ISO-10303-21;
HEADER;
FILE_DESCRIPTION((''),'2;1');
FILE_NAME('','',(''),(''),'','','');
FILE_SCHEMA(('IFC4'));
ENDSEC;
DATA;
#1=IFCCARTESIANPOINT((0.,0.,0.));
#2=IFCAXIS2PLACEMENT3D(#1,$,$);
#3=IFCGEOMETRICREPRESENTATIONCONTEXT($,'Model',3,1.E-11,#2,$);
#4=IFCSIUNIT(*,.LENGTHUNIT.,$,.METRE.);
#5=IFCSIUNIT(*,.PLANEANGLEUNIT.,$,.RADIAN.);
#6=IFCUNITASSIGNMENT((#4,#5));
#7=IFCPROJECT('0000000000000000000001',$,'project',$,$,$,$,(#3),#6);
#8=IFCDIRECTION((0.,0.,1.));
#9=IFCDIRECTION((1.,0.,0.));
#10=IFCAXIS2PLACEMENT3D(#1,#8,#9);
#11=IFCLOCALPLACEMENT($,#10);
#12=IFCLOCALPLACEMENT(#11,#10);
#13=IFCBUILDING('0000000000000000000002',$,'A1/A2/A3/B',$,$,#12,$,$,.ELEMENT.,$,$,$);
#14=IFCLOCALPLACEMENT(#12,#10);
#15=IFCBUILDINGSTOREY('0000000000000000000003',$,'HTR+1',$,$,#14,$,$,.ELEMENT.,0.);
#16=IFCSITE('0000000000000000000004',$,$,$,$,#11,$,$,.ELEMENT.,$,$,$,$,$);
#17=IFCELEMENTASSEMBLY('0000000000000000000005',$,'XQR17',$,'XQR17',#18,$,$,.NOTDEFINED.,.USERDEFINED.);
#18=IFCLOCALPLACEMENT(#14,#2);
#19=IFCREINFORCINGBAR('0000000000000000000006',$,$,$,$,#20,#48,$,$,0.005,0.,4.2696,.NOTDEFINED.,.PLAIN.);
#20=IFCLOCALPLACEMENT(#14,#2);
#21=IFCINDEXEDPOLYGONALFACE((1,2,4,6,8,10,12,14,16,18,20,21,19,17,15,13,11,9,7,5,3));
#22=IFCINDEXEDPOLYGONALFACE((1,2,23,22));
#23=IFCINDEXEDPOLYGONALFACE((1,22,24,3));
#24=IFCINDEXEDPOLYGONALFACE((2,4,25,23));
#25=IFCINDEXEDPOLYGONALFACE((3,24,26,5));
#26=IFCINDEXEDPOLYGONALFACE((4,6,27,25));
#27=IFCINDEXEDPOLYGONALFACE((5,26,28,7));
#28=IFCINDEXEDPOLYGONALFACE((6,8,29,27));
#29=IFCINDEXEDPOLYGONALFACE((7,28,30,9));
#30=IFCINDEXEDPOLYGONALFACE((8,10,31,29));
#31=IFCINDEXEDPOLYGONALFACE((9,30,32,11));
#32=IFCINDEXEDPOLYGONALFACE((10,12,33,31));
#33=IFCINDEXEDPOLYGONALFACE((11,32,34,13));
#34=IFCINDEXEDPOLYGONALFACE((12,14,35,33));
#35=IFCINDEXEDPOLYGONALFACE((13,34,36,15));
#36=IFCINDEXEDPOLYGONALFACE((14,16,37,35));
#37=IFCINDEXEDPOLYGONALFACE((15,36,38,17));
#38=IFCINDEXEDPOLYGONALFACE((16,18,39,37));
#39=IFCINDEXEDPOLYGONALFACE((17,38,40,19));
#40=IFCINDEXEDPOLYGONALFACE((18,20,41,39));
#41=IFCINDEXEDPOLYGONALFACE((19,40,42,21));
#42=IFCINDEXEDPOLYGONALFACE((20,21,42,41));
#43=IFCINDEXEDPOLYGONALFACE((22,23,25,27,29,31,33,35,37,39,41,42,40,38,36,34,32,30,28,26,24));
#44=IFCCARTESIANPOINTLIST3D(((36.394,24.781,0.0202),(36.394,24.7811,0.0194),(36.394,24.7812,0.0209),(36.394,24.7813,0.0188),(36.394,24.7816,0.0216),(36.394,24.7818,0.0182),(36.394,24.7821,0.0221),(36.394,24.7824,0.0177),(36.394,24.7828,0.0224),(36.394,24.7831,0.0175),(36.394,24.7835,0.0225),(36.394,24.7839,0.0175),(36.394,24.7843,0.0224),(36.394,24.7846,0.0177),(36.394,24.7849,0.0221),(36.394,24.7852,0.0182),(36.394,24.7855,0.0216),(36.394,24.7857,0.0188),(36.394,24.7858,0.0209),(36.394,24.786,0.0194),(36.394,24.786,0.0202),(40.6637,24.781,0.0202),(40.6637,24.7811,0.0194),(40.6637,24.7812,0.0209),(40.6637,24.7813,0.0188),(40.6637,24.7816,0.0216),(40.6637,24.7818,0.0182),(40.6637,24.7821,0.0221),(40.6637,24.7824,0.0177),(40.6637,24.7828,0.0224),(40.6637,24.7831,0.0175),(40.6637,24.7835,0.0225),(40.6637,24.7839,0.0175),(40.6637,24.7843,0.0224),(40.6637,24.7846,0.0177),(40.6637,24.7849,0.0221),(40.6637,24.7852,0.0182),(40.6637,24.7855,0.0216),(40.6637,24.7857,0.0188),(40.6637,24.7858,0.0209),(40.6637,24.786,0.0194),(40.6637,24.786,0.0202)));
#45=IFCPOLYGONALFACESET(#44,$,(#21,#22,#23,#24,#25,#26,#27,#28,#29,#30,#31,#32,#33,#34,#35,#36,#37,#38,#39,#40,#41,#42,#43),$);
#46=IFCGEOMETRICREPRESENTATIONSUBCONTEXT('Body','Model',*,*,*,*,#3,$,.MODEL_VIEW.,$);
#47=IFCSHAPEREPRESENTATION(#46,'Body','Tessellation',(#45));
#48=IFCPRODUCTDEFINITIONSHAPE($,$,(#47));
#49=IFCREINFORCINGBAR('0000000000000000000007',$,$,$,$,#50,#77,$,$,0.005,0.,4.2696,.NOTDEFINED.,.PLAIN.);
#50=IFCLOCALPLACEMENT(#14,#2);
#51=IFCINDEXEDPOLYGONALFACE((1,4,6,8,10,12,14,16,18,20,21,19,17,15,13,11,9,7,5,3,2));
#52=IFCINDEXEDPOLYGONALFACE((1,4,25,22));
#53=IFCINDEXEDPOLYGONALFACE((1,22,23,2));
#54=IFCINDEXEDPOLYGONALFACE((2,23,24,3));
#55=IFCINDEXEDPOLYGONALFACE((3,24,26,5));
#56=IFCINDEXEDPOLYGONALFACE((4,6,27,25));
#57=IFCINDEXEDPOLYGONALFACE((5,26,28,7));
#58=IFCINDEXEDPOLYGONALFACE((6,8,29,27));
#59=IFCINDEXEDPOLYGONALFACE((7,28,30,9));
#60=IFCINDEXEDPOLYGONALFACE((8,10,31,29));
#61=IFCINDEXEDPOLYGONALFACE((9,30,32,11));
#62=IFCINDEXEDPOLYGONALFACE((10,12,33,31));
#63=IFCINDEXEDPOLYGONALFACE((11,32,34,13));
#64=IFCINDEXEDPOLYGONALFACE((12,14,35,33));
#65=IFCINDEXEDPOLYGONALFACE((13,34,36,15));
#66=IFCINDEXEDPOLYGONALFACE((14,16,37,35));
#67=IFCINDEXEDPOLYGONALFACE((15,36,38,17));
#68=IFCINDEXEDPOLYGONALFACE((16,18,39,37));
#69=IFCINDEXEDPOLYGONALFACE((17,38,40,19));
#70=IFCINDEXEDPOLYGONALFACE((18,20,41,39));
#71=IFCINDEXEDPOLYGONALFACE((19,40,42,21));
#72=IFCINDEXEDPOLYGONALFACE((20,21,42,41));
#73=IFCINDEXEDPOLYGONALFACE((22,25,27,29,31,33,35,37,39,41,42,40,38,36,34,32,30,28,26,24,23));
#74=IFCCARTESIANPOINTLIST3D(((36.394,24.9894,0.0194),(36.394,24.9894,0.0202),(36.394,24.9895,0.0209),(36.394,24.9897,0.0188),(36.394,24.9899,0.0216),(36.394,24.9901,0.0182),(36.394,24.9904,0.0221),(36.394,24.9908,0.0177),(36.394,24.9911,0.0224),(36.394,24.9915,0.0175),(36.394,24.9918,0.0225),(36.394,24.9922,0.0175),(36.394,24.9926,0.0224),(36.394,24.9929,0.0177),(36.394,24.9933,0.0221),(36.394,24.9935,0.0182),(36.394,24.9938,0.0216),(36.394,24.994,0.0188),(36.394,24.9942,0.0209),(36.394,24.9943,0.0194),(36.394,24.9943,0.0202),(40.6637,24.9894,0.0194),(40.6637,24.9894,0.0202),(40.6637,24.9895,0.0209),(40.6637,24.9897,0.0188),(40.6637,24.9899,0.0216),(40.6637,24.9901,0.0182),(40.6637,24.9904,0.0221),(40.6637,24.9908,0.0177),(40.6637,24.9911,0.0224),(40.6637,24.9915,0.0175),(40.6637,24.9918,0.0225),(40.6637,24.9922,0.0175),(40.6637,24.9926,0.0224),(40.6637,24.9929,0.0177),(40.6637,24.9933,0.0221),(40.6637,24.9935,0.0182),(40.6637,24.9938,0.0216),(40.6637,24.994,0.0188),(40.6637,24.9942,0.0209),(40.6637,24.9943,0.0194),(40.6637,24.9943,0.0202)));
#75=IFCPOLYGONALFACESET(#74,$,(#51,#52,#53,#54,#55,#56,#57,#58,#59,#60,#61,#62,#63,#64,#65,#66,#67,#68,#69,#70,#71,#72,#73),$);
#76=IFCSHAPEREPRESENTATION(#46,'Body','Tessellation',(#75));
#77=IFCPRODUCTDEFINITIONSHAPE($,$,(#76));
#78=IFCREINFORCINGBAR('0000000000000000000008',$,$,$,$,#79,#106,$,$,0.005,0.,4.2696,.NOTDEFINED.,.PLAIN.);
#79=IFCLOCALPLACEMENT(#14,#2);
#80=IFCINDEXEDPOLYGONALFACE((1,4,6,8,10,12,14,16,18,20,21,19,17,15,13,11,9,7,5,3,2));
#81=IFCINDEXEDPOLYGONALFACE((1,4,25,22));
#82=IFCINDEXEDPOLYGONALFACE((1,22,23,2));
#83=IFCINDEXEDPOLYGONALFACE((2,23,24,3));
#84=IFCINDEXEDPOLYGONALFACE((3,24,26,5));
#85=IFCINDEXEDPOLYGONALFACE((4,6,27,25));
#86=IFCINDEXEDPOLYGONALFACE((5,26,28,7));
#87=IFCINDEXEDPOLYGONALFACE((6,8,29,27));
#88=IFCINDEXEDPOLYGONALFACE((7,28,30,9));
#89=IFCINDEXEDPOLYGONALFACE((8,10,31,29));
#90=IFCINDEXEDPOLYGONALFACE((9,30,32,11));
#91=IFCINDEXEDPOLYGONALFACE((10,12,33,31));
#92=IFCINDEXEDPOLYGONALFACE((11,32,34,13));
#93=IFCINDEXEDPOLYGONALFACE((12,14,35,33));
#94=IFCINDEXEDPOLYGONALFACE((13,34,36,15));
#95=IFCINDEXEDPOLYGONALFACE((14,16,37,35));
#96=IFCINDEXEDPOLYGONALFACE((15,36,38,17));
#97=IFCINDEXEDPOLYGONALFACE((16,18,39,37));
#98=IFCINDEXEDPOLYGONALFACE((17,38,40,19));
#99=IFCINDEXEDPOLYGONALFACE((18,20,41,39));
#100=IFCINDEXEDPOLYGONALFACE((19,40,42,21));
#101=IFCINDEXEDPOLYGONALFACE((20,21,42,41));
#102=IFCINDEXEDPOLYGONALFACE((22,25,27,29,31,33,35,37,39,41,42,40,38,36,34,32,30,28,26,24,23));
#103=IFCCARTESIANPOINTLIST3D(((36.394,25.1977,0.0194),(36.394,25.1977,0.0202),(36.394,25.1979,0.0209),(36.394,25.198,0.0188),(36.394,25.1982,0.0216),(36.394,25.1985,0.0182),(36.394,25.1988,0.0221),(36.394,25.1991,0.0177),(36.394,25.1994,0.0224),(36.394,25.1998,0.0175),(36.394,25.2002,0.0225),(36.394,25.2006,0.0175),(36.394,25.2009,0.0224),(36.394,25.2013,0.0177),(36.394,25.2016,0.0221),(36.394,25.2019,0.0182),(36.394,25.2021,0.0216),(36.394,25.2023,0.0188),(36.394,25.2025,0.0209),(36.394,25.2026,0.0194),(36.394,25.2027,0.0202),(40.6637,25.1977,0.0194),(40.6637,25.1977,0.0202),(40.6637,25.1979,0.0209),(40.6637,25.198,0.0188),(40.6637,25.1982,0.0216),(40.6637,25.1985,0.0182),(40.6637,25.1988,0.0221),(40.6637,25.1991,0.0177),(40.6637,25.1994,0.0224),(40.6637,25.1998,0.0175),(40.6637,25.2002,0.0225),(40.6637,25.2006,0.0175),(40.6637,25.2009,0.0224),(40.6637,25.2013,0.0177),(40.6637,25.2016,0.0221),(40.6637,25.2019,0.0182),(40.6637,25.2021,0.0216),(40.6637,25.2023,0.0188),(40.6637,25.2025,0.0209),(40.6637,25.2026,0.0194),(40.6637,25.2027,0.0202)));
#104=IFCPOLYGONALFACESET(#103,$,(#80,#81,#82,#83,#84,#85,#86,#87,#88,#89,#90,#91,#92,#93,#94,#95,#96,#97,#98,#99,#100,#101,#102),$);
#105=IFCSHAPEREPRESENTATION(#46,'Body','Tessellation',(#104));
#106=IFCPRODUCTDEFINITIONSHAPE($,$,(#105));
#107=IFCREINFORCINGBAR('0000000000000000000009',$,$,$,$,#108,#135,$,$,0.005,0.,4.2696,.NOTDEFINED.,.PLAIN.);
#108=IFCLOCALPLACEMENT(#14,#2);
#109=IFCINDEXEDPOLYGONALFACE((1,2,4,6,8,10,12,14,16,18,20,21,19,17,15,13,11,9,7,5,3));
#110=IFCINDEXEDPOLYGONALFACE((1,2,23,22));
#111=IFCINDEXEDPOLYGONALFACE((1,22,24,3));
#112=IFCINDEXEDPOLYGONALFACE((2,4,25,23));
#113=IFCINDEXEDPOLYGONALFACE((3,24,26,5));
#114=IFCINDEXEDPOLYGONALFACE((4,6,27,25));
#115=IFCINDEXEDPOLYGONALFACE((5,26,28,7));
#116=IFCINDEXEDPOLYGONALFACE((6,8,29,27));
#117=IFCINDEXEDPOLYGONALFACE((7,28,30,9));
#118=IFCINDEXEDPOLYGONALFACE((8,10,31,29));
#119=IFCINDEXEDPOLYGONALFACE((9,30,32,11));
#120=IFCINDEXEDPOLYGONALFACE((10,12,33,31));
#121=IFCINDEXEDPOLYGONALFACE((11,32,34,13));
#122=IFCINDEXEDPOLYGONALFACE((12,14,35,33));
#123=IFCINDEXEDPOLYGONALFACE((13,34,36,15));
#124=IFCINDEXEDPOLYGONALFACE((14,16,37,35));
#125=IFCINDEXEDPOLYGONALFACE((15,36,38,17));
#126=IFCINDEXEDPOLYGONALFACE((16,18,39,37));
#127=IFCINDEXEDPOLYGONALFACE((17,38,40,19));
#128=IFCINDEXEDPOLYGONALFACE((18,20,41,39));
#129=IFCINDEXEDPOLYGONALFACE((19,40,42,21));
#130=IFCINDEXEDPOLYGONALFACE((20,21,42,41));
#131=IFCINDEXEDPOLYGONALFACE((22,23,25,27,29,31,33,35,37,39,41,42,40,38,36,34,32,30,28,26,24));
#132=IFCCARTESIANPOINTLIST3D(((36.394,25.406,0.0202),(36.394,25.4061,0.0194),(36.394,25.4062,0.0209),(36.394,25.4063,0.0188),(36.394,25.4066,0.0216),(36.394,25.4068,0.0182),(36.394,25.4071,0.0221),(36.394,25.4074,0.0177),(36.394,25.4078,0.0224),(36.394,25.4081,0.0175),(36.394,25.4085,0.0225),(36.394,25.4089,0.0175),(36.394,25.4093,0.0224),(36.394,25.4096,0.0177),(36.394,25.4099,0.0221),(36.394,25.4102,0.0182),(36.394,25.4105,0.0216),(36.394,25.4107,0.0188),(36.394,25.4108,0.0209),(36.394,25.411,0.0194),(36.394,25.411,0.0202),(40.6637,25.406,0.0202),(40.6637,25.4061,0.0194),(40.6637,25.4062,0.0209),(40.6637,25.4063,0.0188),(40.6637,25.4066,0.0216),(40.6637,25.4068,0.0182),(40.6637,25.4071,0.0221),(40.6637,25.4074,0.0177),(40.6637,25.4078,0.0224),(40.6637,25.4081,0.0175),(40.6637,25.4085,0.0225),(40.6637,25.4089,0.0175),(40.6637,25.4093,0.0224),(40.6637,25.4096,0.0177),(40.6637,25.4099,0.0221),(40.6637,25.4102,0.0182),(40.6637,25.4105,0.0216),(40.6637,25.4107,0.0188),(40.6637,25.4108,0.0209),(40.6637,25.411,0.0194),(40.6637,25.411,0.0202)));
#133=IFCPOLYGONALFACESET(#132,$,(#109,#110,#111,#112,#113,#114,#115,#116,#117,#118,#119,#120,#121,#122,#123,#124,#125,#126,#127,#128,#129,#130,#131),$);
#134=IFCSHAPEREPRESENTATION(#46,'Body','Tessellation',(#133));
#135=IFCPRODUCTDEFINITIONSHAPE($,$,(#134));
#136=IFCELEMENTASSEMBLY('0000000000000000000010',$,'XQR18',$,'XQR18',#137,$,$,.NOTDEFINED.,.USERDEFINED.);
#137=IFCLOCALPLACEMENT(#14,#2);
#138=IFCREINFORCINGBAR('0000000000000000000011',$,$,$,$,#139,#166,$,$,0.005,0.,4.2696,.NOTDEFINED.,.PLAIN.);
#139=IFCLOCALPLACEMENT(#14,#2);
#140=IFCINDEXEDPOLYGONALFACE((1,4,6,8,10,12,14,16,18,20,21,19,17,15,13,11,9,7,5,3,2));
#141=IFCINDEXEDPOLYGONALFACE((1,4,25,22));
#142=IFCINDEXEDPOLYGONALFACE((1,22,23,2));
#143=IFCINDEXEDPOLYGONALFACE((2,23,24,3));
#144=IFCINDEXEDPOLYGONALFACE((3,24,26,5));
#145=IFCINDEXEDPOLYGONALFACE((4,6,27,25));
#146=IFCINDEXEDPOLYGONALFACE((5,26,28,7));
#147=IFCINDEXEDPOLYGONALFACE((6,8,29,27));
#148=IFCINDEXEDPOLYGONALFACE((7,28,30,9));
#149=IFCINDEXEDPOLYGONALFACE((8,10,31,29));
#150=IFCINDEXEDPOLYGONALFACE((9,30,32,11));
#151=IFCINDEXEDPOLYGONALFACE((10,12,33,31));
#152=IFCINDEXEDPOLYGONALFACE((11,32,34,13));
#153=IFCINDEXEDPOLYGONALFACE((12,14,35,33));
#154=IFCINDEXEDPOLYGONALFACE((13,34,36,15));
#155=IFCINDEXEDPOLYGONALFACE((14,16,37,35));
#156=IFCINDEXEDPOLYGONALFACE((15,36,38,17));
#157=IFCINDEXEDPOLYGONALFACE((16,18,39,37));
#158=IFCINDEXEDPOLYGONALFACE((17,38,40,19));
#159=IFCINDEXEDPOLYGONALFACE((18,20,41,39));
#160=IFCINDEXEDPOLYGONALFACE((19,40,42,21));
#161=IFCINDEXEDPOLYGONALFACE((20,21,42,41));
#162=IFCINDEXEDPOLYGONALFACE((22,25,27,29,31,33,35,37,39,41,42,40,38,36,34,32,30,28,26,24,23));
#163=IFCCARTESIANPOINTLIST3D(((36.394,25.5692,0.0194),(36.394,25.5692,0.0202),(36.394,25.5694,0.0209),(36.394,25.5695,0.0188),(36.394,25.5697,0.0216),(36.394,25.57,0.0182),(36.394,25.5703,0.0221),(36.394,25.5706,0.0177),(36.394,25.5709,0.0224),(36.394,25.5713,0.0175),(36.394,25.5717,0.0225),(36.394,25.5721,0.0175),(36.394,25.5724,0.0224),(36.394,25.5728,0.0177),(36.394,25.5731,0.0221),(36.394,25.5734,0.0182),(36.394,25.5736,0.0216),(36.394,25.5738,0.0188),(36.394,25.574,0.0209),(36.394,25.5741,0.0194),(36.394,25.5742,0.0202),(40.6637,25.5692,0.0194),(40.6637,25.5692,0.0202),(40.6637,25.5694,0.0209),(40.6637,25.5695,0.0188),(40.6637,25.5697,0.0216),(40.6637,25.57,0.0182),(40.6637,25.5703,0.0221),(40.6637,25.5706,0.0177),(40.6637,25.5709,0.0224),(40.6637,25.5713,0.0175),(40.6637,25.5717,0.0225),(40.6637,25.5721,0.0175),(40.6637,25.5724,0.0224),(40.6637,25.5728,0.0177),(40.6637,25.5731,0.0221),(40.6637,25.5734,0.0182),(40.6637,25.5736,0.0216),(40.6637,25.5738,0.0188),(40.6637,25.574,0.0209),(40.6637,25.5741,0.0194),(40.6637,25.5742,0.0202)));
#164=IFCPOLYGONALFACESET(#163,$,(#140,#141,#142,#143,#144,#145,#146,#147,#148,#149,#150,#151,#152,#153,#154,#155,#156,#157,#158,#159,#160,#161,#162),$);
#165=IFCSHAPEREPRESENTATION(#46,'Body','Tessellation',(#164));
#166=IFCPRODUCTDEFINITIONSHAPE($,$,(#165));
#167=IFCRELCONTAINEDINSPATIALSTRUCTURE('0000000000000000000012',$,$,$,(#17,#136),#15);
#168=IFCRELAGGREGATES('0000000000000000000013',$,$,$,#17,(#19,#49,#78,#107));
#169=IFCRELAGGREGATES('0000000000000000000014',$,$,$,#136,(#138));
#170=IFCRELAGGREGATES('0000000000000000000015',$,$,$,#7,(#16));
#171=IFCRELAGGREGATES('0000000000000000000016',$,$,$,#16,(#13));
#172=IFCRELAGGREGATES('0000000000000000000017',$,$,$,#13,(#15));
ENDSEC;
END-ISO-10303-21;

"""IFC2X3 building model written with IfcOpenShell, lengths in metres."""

from ifc_helpers import new_model, entity, si_unit, origin, origin_with_axes, place, context, subcontext, project, spatial, shape, element, aggregate, save


model = new_model("IFC2X3")

# Units and contexts
model_context = context("Model", 3, precision=1e-11, world=origin())
body_context = subcontext(model_context, "Body", "Model", "MODEL_VIEW")
ifc_project = project(units=[si_unit("LENGTHUNIT", "METRE"), si_unit("PLANEANGLEUNIT", "RADIAN")], contexts=[model_context])

# Site, building, storey
site_placement = place(None, origin_with_axes())
site = spatial("IfcSite", under=ifc_project, at=site_placement, CompositionType="ELEMENT")
building_placement = place(site_placement, origin_with_axes())
building = spatial("IfcBuilding", under=site, at=building_placement, Name="A1/A2/A3/B", CompositionType="ELEMENT")
storey_placement = place(building_placement, origin_with_axes())
storey = spatial("IfcBuildingStorey", under=building, at=storey_placement, Name="HTR+1", CompositionType="ELEMENT", Elevation=0.0)

# Element assemblies, reinforcing bars
assembly_1_placement = place(storey_placement, origin_with_axes())
assembly_1 = element("IfcElementAssembly", 1, at=assembly_1_placement, inside=storey, Name="XQR17", ObjectType="XQR17", AssemblyPlace="NOTDEFINED", PredefinedType="USERDEFINED")
reinforcing_bar_1_placement = place(assembly_1_placement, origin_with_axes())
reinforcing_bar_1 = element("IfcReinforcingBar", 2, at=reinforcing_bar_1_placement, BarLength=4.2696, BarRole="NOTDEFINED", BarSurface="PLAIN", CrossSectionArea=0.0, NominalDiameter=0.005, shapes=[
    shape(body_context, "Body", "AdvancedSweptSolid", [entity("IfcSweptDiskSolid", entity("IfcPolyline", [entity("IfcCartesianPoint", [36.394, 24.7835, 0.02]), entity("IfcCartesianPoint", [40.6637, 24.7835, 0.02])]), 0.0025, None, 0.0, 4.2696)]),
    shape(body_context, "Body", "AdvancedSweptSolid", [entity("IfcSweptDiskSolid", entity("IfcPolyline", [entity("IfcCartesianPoint", [36.394, 24.7835, 0.02]), entity("IfcCartesianPoint", [40.6637, 24.7835, 0.02])]), 0.0025, None, 0.0, 4.2696)]),
])
reinforcing_bar_2_placement = place(assembly_1_placement, origin_with_axes())
reinforcing_bar_2 = element("IfcReinforcingBar", 3, at=reinforcing_bar_2_placement, BarLength=4.2696, BarRole="NOTDEFINED", BarSurface="PLAIN", CrossSectionArea=0.0, NominalDiameter=0.005, shapes=[
    shape(body_context, "Body", "AdvancedSweptSolid", [entity("IfcSweptDiskSolid", entity("IfcPolyline", [entity("IfcCartesianPoint", [36.394, 24.9918, 0.02]), entity("IfcCartesianPoint", [40.6637, 24.9918, 0.02])]), 0.0025, None, 0.0, 4.2696)]),
    shape(body_context, "Body", "AdvancedSweptSolid", [entity("IfcSweptDiskSolid", entity("IfcPolyline", [entity("IfcCartesianPoint", [36.394, 24.9918, 0.02]), entity("IfcCartesianPoint", [40.6637, 24.9918, 0.02])]), 0.0025, None, 0.0, 4.2696)]),
])
reinforcing_bar_3_placement = place(assembly_1_placement, origin_with_axes())
reinforcing_bar_3 = element("IfcReinforcingBar", 4, at=reinforcing_bar_3_placement, BarLength=4.2696, BarRole="NOTDEFINED", BarSurface="PLAIN", CrossSectionArea=0.0, NominalDiameter=0.005, shapes=[
    shape(body_context, "Body", "AdvancedSweptSolid", [entity("IfcSweptDiskSolid", entity("IfcPolyline", [entity("IfcCartesianPoint", [36.394, 25.2002, 0.02]), entity("IfcCartesianPoint", [40.6637, 25.2002, 0.02])]), 0.0025, None, 0.0, 4.2696)]),
    shape(body_context, "Body", "AdvancedSweptSolid", [entity("IfcSweptDiskSolid", entity("IfcPolyline", [entity("IfcCartesianPoint", [36.394, 25.2002, 0.02]), entity("IfcCartesianPoint", [40.6637, 25.2002, 0.02])]), 0.0025, None, 0.0, 4.2696)]),
])
reinforcing_bar_4_placement = place(assembly_1_placement, origin_with_axes())
reinforcing_bar_4 = element("IfcReinforcingBar", 5, at=reinforcing_bar_4_placement, BarLength=4.2696, BarRole="NOTDEFINED", BarSurface="PLAIN", CrossSectionArea=0.0, NominalDiameter=0.005, shapes=[
    shape(body_context, "Body", "AdvancedSweptSolid", [entity("IfcSweptDiskSolid", entity("IfcPolyline", [entity("IfcCartesianPoint", [36.394, 25.4085, 0.02]), entity("IfcCartesianPoint", [40.6637, 25.4085, 0.02])]), 0.0025, None, 0.0, 4.2696)]),
    shape(body_context, "Body", "AdvancedSweptSolid", [entity("IfcSweptDiskSolid", entity("IfcPolyline", [entity("IfcCartesianPoint", [36.394, 25.4085, 0.02]), entity("IfcCartesianPoint", [40.6637, 25.4085, 0.02])]), 0.0025, None, 0.0, 4.2696)]),
])
aggregate(assembly_1, [reinforcing_bar_1, reinforcing_bar_2, reinforcing_bar_3, reinforcing_bar_4])
assembly_2_placement = place(storey_placement, origin_with_axes())
assembly_2 = element("IfcElementAssembly", 6, at=assembly_2_placement, inside=storey, Name="XQR18", ObjectType="XQR18", AssemblyPlace="NOTDEFINED", PredefinedType="USERDEFINED")
reinforcing_bar_5_placement = place(assembly_2_placement, origin_with_axes())
reinforcing_bar_5 = element("IfcReinforcingBar", 7, at=reinforcing_bar_5_placement, BarLength=4.2696, BarRole="NOTDEFINED", BarSurface="PLAIN", CrossSectionArea=0.0, NominalDiameter=0.005, shapes=[
    shape(body_context, "Body", "AdvancedSweptSolid", [entity("IfcSweptDiskSolid", entity("IfcPolyline", [entity("IfcCartesianPoint", [36.394, 25.5717, 0.02]), entity("IfcCartesianPoint", [40.6637, 25.5717, 0.02])]), 0.0025, None, 0.0, 4.2696)]),
    shape(body_context, "Body", "AdvancedSweptSolid", [entity("IfcSweptDiskSolid", entity("IfcPolyline", [entity("IfcCartesianPoint", [36.394, 25.5717, 0.02]), entity("IfcCartesianPoint", [40.6637, 25.5717, 0.02])]), 0.0025, None, 0.0, 4.2696)]),
])
aggregate(assembly_2, [reinforcing_bar_5])

save(model, "model.ifc")
